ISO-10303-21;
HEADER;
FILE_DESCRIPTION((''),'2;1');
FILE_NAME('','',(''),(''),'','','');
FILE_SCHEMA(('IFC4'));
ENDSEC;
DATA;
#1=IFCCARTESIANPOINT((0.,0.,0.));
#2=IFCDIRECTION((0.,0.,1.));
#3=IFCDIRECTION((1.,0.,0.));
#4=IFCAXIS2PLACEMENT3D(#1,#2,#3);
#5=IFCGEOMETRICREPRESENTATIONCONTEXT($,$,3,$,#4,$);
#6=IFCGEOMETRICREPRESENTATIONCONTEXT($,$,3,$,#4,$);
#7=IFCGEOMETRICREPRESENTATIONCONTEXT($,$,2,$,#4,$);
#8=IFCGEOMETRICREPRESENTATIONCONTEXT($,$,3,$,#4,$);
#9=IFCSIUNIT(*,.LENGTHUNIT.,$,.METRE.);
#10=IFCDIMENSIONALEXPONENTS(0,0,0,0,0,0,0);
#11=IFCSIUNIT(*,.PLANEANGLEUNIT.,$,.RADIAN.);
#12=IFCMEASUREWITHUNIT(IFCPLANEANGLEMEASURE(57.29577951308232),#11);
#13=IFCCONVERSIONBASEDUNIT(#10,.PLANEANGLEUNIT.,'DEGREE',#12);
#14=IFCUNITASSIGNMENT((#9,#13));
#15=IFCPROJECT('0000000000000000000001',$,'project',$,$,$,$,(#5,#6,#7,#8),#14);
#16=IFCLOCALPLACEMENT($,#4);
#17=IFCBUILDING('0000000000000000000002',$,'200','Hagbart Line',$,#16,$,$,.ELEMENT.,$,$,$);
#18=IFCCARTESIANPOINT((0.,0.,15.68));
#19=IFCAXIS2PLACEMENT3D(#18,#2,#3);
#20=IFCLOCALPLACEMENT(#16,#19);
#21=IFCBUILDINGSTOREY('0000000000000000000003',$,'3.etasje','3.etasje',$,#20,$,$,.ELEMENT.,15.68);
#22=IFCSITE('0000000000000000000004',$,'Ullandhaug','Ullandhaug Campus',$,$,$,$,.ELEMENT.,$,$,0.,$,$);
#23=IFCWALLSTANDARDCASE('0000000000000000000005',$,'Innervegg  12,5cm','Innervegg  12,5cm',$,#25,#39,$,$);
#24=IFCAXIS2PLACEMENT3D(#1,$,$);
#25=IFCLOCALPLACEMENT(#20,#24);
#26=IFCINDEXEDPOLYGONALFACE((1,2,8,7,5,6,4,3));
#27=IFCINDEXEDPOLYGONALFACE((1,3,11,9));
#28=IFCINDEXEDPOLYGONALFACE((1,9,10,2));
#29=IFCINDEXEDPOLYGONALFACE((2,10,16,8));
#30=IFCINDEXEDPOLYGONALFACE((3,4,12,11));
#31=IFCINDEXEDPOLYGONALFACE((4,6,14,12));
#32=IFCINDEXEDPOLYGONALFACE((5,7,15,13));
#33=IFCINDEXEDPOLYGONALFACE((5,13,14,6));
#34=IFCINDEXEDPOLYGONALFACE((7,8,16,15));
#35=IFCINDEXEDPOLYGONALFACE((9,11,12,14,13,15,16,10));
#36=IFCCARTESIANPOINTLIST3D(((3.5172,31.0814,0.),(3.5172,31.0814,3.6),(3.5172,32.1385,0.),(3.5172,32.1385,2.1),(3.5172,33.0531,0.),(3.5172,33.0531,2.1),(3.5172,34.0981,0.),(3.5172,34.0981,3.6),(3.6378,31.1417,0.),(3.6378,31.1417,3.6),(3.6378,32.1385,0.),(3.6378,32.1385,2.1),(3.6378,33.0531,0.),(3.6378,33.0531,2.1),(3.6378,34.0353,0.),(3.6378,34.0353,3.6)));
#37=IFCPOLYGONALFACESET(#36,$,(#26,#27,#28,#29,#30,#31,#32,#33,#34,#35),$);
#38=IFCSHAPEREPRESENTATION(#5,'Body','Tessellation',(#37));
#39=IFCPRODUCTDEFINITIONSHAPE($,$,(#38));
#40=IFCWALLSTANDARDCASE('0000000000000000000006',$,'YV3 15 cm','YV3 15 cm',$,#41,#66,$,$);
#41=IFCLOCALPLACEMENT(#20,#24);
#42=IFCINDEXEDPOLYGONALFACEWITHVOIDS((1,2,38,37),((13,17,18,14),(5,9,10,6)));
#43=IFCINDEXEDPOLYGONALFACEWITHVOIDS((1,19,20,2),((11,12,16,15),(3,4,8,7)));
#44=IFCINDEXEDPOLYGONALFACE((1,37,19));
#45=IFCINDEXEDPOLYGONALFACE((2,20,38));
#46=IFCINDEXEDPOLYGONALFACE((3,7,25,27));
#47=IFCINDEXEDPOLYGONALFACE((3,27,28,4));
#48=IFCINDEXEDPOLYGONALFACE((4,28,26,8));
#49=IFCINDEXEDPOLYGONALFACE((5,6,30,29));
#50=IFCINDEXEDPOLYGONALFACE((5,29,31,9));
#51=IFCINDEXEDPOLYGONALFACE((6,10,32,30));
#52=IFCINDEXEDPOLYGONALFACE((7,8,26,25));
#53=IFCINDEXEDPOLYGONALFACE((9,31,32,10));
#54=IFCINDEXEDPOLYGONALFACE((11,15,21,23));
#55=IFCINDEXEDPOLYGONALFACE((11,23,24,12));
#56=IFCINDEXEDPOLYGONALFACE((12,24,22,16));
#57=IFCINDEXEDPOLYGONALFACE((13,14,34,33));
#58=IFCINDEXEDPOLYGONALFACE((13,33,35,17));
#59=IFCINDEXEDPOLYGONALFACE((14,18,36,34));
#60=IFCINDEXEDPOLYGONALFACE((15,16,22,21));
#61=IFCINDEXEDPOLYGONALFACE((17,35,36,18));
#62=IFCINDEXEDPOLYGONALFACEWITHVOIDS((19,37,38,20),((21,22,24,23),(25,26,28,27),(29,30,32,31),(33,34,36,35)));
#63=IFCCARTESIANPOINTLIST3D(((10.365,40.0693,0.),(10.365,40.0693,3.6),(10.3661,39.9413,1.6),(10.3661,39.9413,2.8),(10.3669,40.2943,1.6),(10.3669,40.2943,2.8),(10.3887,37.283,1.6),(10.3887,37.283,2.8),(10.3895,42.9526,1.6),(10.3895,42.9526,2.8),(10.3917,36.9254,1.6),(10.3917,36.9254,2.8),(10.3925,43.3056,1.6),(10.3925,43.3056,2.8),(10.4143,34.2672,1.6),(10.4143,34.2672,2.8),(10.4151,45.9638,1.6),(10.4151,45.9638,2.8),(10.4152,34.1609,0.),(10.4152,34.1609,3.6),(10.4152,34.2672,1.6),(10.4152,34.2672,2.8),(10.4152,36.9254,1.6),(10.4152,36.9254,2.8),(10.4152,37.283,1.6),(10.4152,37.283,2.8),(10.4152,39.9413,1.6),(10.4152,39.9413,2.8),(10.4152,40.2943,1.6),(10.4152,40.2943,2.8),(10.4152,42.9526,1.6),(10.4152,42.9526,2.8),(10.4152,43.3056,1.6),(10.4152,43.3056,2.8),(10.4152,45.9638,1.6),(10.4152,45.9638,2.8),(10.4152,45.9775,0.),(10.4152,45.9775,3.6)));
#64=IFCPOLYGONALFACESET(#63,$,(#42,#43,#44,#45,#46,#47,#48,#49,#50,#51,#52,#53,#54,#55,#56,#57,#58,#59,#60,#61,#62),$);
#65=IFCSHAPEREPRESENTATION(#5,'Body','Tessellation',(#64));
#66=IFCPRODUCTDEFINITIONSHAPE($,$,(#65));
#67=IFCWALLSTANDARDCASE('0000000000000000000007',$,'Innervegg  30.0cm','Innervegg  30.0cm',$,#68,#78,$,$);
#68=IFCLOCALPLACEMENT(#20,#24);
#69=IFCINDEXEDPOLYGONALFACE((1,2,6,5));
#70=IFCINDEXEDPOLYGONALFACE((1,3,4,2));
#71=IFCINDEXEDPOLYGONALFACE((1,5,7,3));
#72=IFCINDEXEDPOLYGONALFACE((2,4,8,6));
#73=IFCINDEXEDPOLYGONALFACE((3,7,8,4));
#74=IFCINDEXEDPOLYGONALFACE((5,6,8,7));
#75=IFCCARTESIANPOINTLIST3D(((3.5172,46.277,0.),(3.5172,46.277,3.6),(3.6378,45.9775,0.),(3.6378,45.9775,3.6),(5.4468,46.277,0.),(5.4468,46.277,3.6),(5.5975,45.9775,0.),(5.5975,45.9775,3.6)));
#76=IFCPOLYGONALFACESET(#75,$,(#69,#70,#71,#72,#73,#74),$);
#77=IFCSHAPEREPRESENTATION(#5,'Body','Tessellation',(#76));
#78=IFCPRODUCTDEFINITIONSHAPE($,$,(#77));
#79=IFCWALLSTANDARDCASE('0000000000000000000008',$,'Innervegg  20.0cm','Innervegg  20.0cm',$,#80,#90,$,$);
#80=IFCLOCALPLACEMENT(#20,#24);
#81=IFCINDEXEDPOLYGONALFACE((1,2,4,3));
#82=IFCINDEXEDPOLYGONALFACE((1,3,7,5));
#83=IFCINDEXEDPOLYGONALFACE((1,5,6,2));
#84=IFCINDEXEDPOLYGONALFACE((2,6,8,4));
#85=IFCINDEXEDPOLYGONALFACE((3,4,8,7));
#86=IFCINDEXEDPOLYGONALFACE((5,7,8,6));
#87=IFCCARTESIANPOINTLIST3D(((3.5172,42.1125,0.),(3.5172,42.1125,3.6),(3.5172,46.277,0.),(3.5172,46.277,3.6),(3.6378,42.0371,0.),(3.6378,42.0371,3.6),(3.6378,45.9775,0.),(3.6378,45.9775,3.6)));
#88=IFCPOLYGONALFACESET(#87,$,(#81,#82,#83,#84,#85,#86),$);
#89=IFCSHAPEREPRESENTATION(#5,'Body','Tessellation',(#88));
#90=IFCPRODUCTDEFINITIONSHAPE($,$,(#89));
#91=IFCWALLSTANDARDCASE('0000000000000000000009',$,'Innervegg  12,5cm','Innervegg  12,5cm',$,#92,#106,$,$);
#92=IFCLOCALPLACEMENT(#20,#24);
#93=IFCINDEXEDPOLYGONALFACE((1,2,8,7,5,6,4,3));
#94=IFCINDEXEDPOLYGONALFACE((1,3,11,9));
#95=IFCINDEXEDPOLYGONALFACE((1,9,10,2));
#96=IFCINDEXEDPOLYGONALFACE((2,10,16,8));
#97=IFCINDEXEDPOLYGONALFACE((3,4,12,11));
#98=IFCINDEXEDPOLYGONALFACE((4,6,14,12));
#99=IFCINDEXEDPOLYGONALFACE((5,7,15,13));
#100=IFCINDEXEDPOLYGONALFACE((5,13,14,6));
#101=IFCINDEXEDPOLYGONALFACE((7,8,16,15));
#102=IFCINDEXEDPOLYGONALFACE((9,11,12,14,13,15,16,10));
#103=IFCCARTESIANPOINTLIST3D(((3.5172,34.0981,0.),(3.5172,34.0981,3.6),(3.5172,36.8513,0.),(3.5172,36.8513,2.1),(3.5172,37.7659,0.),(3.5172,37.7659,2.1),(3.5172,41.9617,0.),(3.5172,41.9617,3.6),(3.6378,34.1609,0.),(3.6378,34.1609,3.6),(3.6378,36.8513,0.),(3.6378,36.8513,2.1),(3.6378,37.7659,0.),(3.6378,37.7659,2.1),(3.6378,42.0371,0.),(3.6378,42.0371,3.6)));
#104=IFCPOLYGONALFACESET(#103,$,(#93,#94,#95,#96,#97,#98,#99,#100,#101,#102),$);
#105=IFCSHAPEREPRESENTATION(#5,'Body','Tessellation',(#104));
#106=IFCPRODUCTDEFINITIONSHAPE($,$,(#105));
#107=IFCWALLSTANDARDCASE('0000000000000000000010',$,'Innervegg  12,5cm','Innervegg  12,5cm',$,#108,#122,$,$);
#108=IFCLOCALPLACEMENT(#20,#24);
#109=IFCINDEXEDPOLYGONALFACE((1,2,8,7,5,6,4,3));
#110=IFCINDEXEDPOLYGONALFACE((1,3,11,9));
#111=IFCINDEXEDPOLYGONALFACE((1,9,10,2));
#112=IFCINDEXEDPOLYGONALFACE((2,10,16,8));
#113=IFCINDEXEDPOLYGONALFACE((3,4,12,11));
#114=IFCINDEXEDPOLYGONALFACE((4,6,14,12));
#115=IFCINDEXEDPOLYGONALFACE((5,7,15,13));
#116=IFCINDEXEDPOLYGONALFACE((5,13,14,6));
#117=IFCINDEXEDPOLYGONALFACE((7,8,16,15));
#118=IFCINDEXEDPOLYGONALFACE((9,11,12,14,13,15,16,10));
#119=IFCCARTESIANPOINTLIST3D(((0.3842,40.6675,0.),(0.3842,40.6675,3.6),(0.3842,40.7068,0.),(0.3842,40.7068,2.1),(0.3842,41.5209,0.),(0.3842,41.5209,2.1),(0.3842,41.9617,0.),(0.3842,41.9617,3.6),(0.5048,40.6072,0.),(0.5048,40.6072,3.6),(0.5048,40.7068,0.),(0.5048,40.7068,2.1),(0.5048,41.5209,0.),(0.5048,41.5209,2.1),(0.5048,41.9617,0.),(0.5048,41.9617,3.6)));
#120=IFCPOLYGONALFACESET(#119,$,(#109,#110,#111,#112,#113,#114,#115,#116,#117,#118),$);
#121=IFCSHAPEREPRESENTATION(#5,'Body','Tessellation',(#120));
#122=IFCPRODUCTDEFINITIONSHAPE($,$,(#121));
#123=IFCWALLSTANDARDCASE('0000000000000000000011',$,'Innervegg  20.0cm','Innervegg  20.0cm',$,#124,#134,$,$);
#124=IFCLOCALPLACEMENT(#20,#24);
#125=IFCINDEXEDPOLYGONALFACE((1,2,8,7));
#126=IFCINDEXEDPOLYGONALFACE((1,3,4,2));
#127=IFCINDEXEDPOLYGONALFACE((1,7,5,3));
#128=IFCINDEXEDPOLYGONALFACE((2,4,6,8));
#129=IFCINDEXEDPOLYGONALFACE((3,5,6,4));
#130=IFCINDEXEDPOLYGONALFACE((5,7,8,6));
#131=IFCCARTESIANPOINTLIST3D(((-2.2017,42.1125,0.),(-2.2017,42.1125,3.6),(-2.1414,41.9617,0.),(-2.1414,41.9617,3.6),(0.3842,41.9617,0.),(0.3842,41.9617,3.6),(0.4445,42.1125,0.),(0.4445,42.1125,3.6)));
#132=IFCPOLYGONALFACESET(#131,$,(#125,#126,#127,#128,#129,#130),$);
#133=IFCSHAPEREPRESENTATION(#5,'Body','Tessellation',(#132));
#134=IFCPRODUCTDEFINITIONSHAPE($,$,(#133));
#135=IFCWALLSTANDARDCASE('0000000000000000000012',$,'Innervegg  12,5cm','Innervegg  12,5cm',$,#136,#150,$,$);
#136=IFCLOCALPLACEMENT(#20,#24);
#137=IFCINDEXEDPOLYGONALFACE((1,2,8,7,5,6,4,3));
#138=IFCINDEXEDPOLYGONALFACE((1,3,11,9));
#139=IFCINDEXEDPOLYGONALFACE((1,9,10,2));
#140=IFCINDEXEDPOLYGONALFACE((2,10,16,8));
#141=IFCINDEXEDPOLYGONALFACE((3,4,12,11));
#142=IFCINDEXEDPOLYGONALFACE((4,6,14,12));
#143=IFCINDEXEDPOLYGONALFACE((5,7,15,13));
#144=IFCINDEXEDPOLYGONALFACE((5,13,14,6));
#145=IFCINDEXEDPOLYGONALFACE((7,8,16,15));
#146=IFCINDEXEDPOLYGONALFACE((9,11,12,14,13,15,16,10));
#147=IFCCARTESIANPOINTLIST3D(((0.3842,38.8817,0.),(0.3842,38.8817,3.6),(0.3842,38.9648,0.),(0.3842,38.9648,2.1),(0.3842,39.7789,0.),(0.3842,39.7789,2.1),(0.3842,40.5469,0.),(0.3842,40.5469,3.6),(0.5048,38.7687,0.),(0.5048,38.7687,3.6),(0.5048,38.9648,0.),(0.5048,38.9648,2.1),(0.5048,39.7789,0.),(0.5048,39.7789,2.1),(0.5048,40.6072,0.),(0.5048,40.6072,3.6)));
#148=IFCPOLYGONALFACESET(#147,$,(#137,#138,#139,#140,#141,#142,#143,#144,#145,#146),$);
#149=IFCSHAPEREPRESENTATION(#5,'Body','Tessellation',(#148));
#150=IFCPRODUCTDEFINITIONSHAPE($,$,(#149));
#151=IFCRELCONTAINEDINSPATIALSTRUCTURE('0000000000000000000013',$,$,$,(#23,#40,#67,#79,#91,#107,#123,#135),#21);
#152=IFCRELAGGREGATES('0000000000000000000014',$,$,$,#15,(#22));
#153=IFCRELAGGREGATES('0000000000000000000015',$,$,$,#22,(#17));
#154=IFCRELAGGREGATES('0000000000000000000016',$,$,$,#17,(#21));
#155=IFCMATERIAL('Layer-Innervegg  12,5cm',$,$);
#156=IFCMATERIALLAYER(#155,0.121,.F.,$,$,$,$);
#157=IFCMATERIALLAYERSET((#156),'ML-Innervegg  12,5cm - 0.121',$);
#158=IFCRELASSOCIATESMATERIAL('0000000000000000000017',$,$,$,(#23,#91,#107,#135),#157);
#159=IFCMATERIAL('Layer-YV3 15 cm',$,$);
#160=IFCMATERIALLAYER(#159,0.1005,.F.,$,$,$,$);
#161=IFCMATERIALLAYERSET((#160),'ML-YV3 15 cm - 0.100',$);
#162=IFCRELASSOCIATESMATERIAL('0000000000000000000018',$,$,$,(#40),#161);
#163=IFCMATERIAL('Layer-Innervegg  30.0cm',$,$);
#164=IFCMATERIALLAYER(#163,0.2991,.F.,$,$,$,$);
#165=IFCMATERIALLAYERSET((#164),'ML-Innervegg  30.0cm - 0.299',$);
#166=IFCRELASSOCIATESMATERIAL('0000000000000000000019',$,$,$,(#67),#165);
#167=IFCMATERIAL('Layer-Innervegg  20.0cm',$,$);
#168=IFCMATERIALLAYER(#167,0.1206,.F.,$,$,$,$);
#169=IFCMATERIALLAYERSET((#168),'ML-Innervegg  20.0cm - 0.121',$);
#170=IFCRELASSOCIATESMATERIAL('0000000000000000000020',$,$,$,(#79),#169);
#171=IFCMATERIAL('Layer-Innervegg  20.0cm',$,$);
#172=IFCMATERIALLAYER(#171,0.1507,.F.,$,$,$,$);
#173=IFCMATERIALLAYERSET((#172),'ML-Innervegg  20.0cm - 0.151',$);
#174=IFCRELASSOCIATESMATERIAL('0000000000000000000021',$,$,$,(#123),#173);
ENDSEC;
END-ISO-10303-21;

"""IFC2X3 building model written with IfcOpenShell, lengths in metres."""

from ifc_helpers import new_model, entity, si_unit, converted_unit, frame, origin_with_axes, place, context, project, spatial, polyline, outline, extrude, material, layer, layer_set, layer_usage, element, save


model = new_model("IFC2X3")

# Units and contexts
context_of_model_1 = context(None, 3, world=origin_with_axes())
context_of_model_2 = context(None, 3, world=origin_with_axes())
context_of_model_3 = context(None, 2, world=origin_with_axes())
context_of_model_4 = context(None, 3, world=origin_with_axes())
ifc_project = project(units=[si_unit("LENGTHUNIT", "METRE"), converted_unit("PLANEANGLEUNIT", "DEGREE", entity("IfcPlaneAngleMeasure", 57.29577951308232), si_unit("PLANEANGLEUNIT", "RADIAN"), dimensions=[0, 0, 0, 0, 0, 0, 0])], contexts=[context_of_model_1, context_of_model_2, context_of_model_3, context_of_model_4])

# Site, building, storey
site = spatial("IfcSite", under=ifc_project, Name="Ullandhaug", Description="Ullandhaug Campus", CompositionType="ELEMENT", RefElevation=0.0)
building_placement = place(None, origin_with_axes())
building = spatial("IfcBuilding", under=site, at=building_placement, Name="200", Description="Hagbart Line", CompositionType="ELEMENT")
storey_placement = place(building_placement, frame((0.0, 0.0, 15.68), z_axis=(0.0, 0.0, 1.0), x_axis=(1.0, 0.0, 0.0)))
storey = spatial("IfcBuildingStorey", under=building, at=storey_placement, Name="3.etasje", Description="3.etasje", CompositionType="ELEMENT", Elevation=15.68)

# Shared definitions
ifc_material_1 = material(Name="Layer-Innervegg  12,5cm")
ifc_layer_1 = layer(ifc_material_1, 0.121, ventilated=False)
ifc_layer_set_1 = layer_set([ifc_layer_1], Name="ML-Innervegg  12,5cm - 0.121")
ifc_layer_usage_1 = layer_usage(ifc_layer_set_1, "AXIS2", "POSITIVE", 0.0)

# Wall, opening
wall_1_placement = place(storey_placement, frame((3.5172, 34.0981, 0.0), z_axis=(0.0, 0.0, 1.0), x_axis=(0.0, -1.0, 0.0)))
wall_1 = element("IfcWallStandardCase", 1, at=wall_1_placement, inside=storey, material=ifc_layer_usage_1, Name="Innervegg  12,5cm", Description="Innervegg  12,5cm", context=context_of_model_1, shape_type="SweptSolid", body=[
    extrude(outline(polyline([(0.0, 0.0), (3.0167, 0.0), (2.9564, 0.1206), (0.0628, 0.1206), (0.0, 0.0)])), frame((0.0, 0.0, 0.0), z_axis=(0.0, 0.0, 1.0), x_axis=(1.0, 0.0, 0.0)), (0.0, 0.0, 1.0), 3.6),
])
opening_1_placement = place(wall_1_placement, frame((1.045, 0.1206, 0.0), z_axis=(0.0, 0.0, 1.0), x_axis=(1.0, 0.0, 0.0)))
element("IfcOpeningElement", 2, at=opening_1_placement, cuts=wall_1, context=context_of_model_1, shape_type="SweptSolid", body=[
    extrude(outline(polyline([(0.0, 0.0), (2.1, 0.0), (2.1, 0.9145), (0.0, 0.9145), (0.0, 0.0)])), frame((0.0, 0.0, 0.0), z_axis=(0.0, 1.0, 0.0), x_axis=(0.0, 0.0, 1.0)), (0.0, 0.0, -1.0), 0.1206),
])

# Wall, openings
ifc_material_2 = material(Name="Layer-YV3 15 cm")
ifc_layer_2 = layer(ifc_material_2, 0.1005, ventilated=False)
ifc_layer_set_2 = layer_set([ifc_layer_2], Name="ML-YV3 15 cm - 0.100")
ifc_layer_usage_2 = layer_usage(ifc_layer_set_2, "AXIS2", "POSITIVE", 0.0)
wall_2_placement = place(storey_placement, frame((10.3147, 34.1609, 0.0), z_axis=(0.0, 0.0, 1.0), x_axis=(0.0, 1.0, 0.0)))
wall_2 = element("IfcWallStandardCase", 3, at=wall_2_placement, inside=storey, material=ifc_layer_usage_2, Name="YV3 15 cm", Description="YV3 15 cm", context=context_of_model_1, shape_type="SweptSolid", body=[
    extrude(outline(polyline([(0.0, 0.0), (11.8166, 0.0), (0.0, 0.1005), (11.8166, 0.1005), (0.0, 0.0)])), frame((0.0, 0.0, 0.0), z_axis=(0.0, 0.0, -1.0), x_axis=(1.0, 0.0, 0.0)), (0.0, 0.0, -1.0), 3.6),
])
opening_2_placement = place(wall_2_placement, frame((0.1063, 0.0, 1.6), z_axis=(0.0, 0.0, 1.0), x_axis=(1.0, 0.0, 0.0)))
element("IfcOpeningElement", 4, at=opening_2_placement, cuts=wall_2, context=context_of_model_1, shape_type="SweptSolid", body=[
    extrude(outline(polyline([(0.0, 0.0), (1.2, 0.0), (1.2, 2.6582), (0.0, 2.6582), (0.0, 0.0)])), frame((0.0, 0.0, 0.0), z_axis=(0.0, 1.0, 0.0), x_axis=(0.0, 0.0, 1.0)), (0.0, 0.0, -1.0), 0.1005),
])
opening_3_placement = place(wall_2_placement, frame((3.1221, 0.0, 1.6), z_axis=(0.0, 0.0, 1.0), x_axis=(1.0, 0.0, 0.0)))
element("IfcOpeningElement", 5, at=opening_3_placement, cuts=wall_2, context=context_of_model_1, shape_type="SweptSolid", body=[
    extrude(outline(polyline([(0.0, 0.0), (1.2, 0.0), (1.2, 2.6582), (0.0, 2.6582), (0.0, 0.0)])), frame((0.0, 0.0, 0.0), z_axis=(0.0, 1.0, 0.0), x_axis=(0.0, 0.0, 1.0)), (0.0, 0.0, -1.0), 0.1005),
])
opening_4_placement = place(wall_2_placement, frame((6.1334, 0.0, 1.6), z_axis=(0.0, 0.0, 1.0), x_axis=(1.0, 0.0, 0.0)))
element("IfcOpeningElement", 6, at=opening_4_placement, cuts=wall_2, context=context_of_model_1, shape_type="SweptSolid", body=[
    extrude(outline(polyline([(0.0, 0.0), (1.2, 0.0), (1.2, 2.6582), (0.0, 2.6582), (0.0, 0.0)])), frame((0.0, 0.0, 0.0), z_axis=(0.0, 1.0, 0.0), x_axis=(0.0, 0.0, 1.0)), (0.0, 0.0, -1.0), 0.1005),
])
opening_5_placement = place(wall_2_placement, frame((9.1447, 0.0, 1.6), z_axis=(0.0, 0.0, 1.0), x_axis=(1.0, 0.0, 0.0)))
element("IfcOpeningElement", 7, at=opening_5_placement, cuts=wall_2, context=context_of_model_1, shape_type="SweptSolid", body=[
    extrude(outline(polyline([(0.0, 0.0), (1.2, 0.0), (1.2, 2.6582), (0.0, 2.6582), (0.0, 0.0)])), frame((0.0, 0.0, 0.0), z_axis=(0.0, 1.0, 0.0), x_axis=(0.0, 0.0, 1.0)), (0.0, 0.0, -1.0), 0.1005),
])

# Walls
ifc_material_3 = material(Name="Layer-Innervegg  30.0cm")
ifc_layer_3 = layer(ifc_material_3, 0.2991, ventilated=False)
ifc_layer_set_3 = layer_set([ifc_layer_3], Name="ML-Innervegg  30.0cm - 0.299")
ifc_layer_usage_3 = layer_usage(ifc_layer_set_3, "AXIS2", "POSITIVE", 0.0)
wall_3_placement = place(storey_placement, frame((5.4468, 46.277, 0.0), z_axis=(0.0, 0.0, 1.0), x_axis=(-1.0, 0.0, 0.0)))
element("IfcWallStandardCase", 8, at=wall_3_placement, inside=storey, material=ifc_layer_usage_3, Name="Innervegg  30.0cm", Description="Innervegg  30.0cm", context=context_of_model_1, shape_type="SweptSolid", body=[
    extrude(outline(polyline([(0.0, 0.0), (1.9296, 0.0), (1.809, 0.2994), (-0.1508, 0.2994), (0.0, 0.0)])), frame((0.0, 0.0, 0.0), z_axis=(0.0, 0.0, 1.0), x_axis=(1.0, 0.0, 0.0)), (0.0, 0.0, 1.0), 3.6),
])
ifc_material_4 = material(Name="Layer-Innervegg  20.0cm")
ifc_layer_4 = layer(ifc_material_4, 0.1206, ventilated=False)
ifc_layer_set_4 = layer_set([ifc_layer_4], Name="ML-Innervegg  20.0cm - 0.121")
ifc_layer_usage_4 = layer_usage(ifc_layer_set_4, "AXIS2", "POSITIVE", 0.0)
wall_4_placement = place(storey_placement, frame((3.5172, 46.277, 0.0), z_axis=(0.0, 0.0, 1.0), x_axis=(0.0, -1.0, 0.0)))
element("IfcWallStandardCase", 9, at=wall_4_placement, inside=storey, material=ifc_layer_usage_4, Name="Innervegg  20.0cm", Description="Innervegg  20.0cm", context=context_of_model_1, shape_type="SweptSolid", body=[
    extrude(outline(polyline([(0.0, 0.0), (4.1645, 0.0), (4.2398, 0.1206), (0.2994, 0.1206), (0.0, 0.0)])), frame((0.0, 0.0, 0.0), z_axis=(0.0, 0.0, 1.0), x_axis=(1.0, 0.0, 0.0)), (0.0, 0.0, 1.0), 3.6),
])

# Walls, openings
wall_5_placement = place(storey_placement, frame((3.5172, 41.9617, 0.0), z_axis=(0.0, 0.0, 1.0), x_axis=(0.0, -1.0, 0.0)))
wall_5 = element("IfcWallStandardCase", 10, at=wall_5_placement, inside=storey, material=ifc_layer_usage_1, Name="Innervegg  12,5cm", Description="Innervegg  12,5cm", context=context_of_model_1, shape_type="SweptSolid", body=[
    extrude(outline(polyline([(0.0, 0.0), (7.8636, 0.0), (7.8008, 0.1206), (-0.0754, 0.1206), (0.0, 0.0)])), frame((0.0, 0.0, 0.0), z_axis=(0.0, 0.0, 1.0), x_axis=(1.0, 0.0, 0.0)), (0.0, 0.0, 1.0), 3.6),
])
opening_6_placement = place(wall_5_placement, frame((4.1958, 0.1206, 0.0), z_axis=(0.0, 0.0, 1.0), x_axis=(1.0, 0.0, 0.0)))
element("IfcOpeningElement", 11, at=opening_6_placement, cuts=wall_5, context=context_of_model_1, shape_type="SweptSolid", body=[
    extrude(outline(polyline([(0.0, 0.0), (2.1, 0.0), (2.1, 0.9146), (0.0, 0.9146), (0.0, 0.0)])), frame((0.0, 0.0, 0.0), z_axis=(0.0, 1.0, 0.0), x_axis=(0.0, 0.0, 1.0)), (0.0, 0.0, -1.0), 0.1206),
])
wall_6_placement = place(storey_placement, frame((0.5048, 40.6072, 0.0), z_axis=(0.0, 0.0, 1.0), x_axis=(0.0, 1.0, 0.0)))
wall_6 = element("IfcWallStandardCase", 12, at=wall_6_placement, inside=storey, material=ifc_layer_usage_1, Name="Innervegg  12,5cm", Description="Innervegg  12,5cm", context=context_of_model_1, shape_type="SweptSolid", body=[
    extrude(outline(polyline([(0.0, 0.0), (1.3545, 0.0), (1.3545, 0.1206), (0.0603, 0.1206), (0.0, 0.0)])), frame((0.0, 0.0, 0.0), z_axis=(0.0, 0.0, 1.0), x_axis=(1.0, 0.0, 0.0)), (0.0, 0.0, 1.0), 3.6),
])
opening_7_placement = place(wall_6_placement, frame((0.0996, 0.1206, 0.0), z_axis=(0.0, 0.0, 1.0), x_axis=(1.0, 0.0, 0.0)))
element("IfcOpeningElement", 13, at=opening_7_placement, cuts=wall_6, context=context_of_model_1, shape_type="SweptSolid", body=[
    extrude(outline(polyline([(0.0, 0.0), (2.1, 0.0), (2.1, 0.814), (0.0, 0.814), (0.0, 0.0)])), frame((0.0, 0.0, 0.0), z_axis=(0.0, 1.0, 0.0), x_axis=(0.0, 0.0, 1.0)), (0.0, 0.0, -1.0), 0.1206),
])

# Wall
ifc_material_5 = material(Name="Layer-Innervegg  20.0cm")
ifc_layer_5 = layer(ifc_material_5, 0.1507, ventilated=False)
ifc_layer_set_5 = layer_set([ifc_layer_5], Name="ML-Innervegg  20.0cm - 0.151")
ifc_layer_usage_5 = layer_usage(ifc_layer_set_5, "AXIS2", "POSITIVE", 0.0)
wall_7_placement = place(storey_placement, frame((0.4445, 42.1125, 0.0), z_axis=(0.0, 0.0, 1.0), x_axis=(-1.0, 0.0, 0.0)))
element("IfcWallStandardCase", 14, at=wall_7_placement, inside=storey, material=ifc_layer_usage_5, Name="Innervegg  20.0cm", Description="Innervegg  20.0cm", context=context_of_model_1, shape_type="SweptSolid", body=[
    extrude(outline(polyline([(0.0, 0.0), (2.6462, 0.0), (2.5859, 0.1507), (0.0603, 0.1507), (0.0, 0.0)])), frame((0.0, 0.0, 0.0), z_axis=(0.0, 0.0, 1.0), x_axis=(1.0, 0.0, 0.0)), (0.0, 0.0, 1.0), 3.6),
])

# Wall, opening
wall_8_placement = place(storey_placement, frame((0.5048, 38.7687, 0.0), z_axis=(0.0, 0.0, 1.0), x_axis=(0.0, 1.0, 0.0)))
wall_8 = element("IfcWallStandardCase", 15, at=wall_8_placement, inside=storey, material=ifc_layer_usage_1, Name="Innervegg  12,5cm", Description="Innervegg  12,5cm", context=context_of_model_1, shape_type="SweptSolid", body=[
    extrude(outline(polyline([(0.0, 0.0), (1.8386, 0.0), (1.7783, 0.1206), (0.1131, 0.1206), (0.0, 0.0)])), frame((0.0, 0.0, 0.0), z_axis=(0.0, 0.0, 1.0), x_axis=(1.0, 0.0, 0.0)), (0.0, 0.0, 1.0), 3.6),
])
opening_8_placement = place(wall_8_placement, frame((0.1962, 0.1206, 0.0), z_axis=(0.0, 0.0, 1.0), x_axis=(1.0, 0.0, 0.0)))
element("IfcOpeningElement", 16, at=opening_8_placement, cuts=wall_8, context=context_of_model_1, shape_type="SweptSolid", body=[
    extrude(outline(polyline([(0.0, 0.0), (2.1, 0.0), (2.1, 0.8141), (0.0, 0.8141), (0.0, 0.0)])), frame((0.0, 0.0, 0.0), z_axis=(0.0, 1.0, 0.0), x_axis=(0.0, 0.0, 1.0)), (0.0, 0.0, -1.0), 0.1206),
])

save(model, "model.ifc")
